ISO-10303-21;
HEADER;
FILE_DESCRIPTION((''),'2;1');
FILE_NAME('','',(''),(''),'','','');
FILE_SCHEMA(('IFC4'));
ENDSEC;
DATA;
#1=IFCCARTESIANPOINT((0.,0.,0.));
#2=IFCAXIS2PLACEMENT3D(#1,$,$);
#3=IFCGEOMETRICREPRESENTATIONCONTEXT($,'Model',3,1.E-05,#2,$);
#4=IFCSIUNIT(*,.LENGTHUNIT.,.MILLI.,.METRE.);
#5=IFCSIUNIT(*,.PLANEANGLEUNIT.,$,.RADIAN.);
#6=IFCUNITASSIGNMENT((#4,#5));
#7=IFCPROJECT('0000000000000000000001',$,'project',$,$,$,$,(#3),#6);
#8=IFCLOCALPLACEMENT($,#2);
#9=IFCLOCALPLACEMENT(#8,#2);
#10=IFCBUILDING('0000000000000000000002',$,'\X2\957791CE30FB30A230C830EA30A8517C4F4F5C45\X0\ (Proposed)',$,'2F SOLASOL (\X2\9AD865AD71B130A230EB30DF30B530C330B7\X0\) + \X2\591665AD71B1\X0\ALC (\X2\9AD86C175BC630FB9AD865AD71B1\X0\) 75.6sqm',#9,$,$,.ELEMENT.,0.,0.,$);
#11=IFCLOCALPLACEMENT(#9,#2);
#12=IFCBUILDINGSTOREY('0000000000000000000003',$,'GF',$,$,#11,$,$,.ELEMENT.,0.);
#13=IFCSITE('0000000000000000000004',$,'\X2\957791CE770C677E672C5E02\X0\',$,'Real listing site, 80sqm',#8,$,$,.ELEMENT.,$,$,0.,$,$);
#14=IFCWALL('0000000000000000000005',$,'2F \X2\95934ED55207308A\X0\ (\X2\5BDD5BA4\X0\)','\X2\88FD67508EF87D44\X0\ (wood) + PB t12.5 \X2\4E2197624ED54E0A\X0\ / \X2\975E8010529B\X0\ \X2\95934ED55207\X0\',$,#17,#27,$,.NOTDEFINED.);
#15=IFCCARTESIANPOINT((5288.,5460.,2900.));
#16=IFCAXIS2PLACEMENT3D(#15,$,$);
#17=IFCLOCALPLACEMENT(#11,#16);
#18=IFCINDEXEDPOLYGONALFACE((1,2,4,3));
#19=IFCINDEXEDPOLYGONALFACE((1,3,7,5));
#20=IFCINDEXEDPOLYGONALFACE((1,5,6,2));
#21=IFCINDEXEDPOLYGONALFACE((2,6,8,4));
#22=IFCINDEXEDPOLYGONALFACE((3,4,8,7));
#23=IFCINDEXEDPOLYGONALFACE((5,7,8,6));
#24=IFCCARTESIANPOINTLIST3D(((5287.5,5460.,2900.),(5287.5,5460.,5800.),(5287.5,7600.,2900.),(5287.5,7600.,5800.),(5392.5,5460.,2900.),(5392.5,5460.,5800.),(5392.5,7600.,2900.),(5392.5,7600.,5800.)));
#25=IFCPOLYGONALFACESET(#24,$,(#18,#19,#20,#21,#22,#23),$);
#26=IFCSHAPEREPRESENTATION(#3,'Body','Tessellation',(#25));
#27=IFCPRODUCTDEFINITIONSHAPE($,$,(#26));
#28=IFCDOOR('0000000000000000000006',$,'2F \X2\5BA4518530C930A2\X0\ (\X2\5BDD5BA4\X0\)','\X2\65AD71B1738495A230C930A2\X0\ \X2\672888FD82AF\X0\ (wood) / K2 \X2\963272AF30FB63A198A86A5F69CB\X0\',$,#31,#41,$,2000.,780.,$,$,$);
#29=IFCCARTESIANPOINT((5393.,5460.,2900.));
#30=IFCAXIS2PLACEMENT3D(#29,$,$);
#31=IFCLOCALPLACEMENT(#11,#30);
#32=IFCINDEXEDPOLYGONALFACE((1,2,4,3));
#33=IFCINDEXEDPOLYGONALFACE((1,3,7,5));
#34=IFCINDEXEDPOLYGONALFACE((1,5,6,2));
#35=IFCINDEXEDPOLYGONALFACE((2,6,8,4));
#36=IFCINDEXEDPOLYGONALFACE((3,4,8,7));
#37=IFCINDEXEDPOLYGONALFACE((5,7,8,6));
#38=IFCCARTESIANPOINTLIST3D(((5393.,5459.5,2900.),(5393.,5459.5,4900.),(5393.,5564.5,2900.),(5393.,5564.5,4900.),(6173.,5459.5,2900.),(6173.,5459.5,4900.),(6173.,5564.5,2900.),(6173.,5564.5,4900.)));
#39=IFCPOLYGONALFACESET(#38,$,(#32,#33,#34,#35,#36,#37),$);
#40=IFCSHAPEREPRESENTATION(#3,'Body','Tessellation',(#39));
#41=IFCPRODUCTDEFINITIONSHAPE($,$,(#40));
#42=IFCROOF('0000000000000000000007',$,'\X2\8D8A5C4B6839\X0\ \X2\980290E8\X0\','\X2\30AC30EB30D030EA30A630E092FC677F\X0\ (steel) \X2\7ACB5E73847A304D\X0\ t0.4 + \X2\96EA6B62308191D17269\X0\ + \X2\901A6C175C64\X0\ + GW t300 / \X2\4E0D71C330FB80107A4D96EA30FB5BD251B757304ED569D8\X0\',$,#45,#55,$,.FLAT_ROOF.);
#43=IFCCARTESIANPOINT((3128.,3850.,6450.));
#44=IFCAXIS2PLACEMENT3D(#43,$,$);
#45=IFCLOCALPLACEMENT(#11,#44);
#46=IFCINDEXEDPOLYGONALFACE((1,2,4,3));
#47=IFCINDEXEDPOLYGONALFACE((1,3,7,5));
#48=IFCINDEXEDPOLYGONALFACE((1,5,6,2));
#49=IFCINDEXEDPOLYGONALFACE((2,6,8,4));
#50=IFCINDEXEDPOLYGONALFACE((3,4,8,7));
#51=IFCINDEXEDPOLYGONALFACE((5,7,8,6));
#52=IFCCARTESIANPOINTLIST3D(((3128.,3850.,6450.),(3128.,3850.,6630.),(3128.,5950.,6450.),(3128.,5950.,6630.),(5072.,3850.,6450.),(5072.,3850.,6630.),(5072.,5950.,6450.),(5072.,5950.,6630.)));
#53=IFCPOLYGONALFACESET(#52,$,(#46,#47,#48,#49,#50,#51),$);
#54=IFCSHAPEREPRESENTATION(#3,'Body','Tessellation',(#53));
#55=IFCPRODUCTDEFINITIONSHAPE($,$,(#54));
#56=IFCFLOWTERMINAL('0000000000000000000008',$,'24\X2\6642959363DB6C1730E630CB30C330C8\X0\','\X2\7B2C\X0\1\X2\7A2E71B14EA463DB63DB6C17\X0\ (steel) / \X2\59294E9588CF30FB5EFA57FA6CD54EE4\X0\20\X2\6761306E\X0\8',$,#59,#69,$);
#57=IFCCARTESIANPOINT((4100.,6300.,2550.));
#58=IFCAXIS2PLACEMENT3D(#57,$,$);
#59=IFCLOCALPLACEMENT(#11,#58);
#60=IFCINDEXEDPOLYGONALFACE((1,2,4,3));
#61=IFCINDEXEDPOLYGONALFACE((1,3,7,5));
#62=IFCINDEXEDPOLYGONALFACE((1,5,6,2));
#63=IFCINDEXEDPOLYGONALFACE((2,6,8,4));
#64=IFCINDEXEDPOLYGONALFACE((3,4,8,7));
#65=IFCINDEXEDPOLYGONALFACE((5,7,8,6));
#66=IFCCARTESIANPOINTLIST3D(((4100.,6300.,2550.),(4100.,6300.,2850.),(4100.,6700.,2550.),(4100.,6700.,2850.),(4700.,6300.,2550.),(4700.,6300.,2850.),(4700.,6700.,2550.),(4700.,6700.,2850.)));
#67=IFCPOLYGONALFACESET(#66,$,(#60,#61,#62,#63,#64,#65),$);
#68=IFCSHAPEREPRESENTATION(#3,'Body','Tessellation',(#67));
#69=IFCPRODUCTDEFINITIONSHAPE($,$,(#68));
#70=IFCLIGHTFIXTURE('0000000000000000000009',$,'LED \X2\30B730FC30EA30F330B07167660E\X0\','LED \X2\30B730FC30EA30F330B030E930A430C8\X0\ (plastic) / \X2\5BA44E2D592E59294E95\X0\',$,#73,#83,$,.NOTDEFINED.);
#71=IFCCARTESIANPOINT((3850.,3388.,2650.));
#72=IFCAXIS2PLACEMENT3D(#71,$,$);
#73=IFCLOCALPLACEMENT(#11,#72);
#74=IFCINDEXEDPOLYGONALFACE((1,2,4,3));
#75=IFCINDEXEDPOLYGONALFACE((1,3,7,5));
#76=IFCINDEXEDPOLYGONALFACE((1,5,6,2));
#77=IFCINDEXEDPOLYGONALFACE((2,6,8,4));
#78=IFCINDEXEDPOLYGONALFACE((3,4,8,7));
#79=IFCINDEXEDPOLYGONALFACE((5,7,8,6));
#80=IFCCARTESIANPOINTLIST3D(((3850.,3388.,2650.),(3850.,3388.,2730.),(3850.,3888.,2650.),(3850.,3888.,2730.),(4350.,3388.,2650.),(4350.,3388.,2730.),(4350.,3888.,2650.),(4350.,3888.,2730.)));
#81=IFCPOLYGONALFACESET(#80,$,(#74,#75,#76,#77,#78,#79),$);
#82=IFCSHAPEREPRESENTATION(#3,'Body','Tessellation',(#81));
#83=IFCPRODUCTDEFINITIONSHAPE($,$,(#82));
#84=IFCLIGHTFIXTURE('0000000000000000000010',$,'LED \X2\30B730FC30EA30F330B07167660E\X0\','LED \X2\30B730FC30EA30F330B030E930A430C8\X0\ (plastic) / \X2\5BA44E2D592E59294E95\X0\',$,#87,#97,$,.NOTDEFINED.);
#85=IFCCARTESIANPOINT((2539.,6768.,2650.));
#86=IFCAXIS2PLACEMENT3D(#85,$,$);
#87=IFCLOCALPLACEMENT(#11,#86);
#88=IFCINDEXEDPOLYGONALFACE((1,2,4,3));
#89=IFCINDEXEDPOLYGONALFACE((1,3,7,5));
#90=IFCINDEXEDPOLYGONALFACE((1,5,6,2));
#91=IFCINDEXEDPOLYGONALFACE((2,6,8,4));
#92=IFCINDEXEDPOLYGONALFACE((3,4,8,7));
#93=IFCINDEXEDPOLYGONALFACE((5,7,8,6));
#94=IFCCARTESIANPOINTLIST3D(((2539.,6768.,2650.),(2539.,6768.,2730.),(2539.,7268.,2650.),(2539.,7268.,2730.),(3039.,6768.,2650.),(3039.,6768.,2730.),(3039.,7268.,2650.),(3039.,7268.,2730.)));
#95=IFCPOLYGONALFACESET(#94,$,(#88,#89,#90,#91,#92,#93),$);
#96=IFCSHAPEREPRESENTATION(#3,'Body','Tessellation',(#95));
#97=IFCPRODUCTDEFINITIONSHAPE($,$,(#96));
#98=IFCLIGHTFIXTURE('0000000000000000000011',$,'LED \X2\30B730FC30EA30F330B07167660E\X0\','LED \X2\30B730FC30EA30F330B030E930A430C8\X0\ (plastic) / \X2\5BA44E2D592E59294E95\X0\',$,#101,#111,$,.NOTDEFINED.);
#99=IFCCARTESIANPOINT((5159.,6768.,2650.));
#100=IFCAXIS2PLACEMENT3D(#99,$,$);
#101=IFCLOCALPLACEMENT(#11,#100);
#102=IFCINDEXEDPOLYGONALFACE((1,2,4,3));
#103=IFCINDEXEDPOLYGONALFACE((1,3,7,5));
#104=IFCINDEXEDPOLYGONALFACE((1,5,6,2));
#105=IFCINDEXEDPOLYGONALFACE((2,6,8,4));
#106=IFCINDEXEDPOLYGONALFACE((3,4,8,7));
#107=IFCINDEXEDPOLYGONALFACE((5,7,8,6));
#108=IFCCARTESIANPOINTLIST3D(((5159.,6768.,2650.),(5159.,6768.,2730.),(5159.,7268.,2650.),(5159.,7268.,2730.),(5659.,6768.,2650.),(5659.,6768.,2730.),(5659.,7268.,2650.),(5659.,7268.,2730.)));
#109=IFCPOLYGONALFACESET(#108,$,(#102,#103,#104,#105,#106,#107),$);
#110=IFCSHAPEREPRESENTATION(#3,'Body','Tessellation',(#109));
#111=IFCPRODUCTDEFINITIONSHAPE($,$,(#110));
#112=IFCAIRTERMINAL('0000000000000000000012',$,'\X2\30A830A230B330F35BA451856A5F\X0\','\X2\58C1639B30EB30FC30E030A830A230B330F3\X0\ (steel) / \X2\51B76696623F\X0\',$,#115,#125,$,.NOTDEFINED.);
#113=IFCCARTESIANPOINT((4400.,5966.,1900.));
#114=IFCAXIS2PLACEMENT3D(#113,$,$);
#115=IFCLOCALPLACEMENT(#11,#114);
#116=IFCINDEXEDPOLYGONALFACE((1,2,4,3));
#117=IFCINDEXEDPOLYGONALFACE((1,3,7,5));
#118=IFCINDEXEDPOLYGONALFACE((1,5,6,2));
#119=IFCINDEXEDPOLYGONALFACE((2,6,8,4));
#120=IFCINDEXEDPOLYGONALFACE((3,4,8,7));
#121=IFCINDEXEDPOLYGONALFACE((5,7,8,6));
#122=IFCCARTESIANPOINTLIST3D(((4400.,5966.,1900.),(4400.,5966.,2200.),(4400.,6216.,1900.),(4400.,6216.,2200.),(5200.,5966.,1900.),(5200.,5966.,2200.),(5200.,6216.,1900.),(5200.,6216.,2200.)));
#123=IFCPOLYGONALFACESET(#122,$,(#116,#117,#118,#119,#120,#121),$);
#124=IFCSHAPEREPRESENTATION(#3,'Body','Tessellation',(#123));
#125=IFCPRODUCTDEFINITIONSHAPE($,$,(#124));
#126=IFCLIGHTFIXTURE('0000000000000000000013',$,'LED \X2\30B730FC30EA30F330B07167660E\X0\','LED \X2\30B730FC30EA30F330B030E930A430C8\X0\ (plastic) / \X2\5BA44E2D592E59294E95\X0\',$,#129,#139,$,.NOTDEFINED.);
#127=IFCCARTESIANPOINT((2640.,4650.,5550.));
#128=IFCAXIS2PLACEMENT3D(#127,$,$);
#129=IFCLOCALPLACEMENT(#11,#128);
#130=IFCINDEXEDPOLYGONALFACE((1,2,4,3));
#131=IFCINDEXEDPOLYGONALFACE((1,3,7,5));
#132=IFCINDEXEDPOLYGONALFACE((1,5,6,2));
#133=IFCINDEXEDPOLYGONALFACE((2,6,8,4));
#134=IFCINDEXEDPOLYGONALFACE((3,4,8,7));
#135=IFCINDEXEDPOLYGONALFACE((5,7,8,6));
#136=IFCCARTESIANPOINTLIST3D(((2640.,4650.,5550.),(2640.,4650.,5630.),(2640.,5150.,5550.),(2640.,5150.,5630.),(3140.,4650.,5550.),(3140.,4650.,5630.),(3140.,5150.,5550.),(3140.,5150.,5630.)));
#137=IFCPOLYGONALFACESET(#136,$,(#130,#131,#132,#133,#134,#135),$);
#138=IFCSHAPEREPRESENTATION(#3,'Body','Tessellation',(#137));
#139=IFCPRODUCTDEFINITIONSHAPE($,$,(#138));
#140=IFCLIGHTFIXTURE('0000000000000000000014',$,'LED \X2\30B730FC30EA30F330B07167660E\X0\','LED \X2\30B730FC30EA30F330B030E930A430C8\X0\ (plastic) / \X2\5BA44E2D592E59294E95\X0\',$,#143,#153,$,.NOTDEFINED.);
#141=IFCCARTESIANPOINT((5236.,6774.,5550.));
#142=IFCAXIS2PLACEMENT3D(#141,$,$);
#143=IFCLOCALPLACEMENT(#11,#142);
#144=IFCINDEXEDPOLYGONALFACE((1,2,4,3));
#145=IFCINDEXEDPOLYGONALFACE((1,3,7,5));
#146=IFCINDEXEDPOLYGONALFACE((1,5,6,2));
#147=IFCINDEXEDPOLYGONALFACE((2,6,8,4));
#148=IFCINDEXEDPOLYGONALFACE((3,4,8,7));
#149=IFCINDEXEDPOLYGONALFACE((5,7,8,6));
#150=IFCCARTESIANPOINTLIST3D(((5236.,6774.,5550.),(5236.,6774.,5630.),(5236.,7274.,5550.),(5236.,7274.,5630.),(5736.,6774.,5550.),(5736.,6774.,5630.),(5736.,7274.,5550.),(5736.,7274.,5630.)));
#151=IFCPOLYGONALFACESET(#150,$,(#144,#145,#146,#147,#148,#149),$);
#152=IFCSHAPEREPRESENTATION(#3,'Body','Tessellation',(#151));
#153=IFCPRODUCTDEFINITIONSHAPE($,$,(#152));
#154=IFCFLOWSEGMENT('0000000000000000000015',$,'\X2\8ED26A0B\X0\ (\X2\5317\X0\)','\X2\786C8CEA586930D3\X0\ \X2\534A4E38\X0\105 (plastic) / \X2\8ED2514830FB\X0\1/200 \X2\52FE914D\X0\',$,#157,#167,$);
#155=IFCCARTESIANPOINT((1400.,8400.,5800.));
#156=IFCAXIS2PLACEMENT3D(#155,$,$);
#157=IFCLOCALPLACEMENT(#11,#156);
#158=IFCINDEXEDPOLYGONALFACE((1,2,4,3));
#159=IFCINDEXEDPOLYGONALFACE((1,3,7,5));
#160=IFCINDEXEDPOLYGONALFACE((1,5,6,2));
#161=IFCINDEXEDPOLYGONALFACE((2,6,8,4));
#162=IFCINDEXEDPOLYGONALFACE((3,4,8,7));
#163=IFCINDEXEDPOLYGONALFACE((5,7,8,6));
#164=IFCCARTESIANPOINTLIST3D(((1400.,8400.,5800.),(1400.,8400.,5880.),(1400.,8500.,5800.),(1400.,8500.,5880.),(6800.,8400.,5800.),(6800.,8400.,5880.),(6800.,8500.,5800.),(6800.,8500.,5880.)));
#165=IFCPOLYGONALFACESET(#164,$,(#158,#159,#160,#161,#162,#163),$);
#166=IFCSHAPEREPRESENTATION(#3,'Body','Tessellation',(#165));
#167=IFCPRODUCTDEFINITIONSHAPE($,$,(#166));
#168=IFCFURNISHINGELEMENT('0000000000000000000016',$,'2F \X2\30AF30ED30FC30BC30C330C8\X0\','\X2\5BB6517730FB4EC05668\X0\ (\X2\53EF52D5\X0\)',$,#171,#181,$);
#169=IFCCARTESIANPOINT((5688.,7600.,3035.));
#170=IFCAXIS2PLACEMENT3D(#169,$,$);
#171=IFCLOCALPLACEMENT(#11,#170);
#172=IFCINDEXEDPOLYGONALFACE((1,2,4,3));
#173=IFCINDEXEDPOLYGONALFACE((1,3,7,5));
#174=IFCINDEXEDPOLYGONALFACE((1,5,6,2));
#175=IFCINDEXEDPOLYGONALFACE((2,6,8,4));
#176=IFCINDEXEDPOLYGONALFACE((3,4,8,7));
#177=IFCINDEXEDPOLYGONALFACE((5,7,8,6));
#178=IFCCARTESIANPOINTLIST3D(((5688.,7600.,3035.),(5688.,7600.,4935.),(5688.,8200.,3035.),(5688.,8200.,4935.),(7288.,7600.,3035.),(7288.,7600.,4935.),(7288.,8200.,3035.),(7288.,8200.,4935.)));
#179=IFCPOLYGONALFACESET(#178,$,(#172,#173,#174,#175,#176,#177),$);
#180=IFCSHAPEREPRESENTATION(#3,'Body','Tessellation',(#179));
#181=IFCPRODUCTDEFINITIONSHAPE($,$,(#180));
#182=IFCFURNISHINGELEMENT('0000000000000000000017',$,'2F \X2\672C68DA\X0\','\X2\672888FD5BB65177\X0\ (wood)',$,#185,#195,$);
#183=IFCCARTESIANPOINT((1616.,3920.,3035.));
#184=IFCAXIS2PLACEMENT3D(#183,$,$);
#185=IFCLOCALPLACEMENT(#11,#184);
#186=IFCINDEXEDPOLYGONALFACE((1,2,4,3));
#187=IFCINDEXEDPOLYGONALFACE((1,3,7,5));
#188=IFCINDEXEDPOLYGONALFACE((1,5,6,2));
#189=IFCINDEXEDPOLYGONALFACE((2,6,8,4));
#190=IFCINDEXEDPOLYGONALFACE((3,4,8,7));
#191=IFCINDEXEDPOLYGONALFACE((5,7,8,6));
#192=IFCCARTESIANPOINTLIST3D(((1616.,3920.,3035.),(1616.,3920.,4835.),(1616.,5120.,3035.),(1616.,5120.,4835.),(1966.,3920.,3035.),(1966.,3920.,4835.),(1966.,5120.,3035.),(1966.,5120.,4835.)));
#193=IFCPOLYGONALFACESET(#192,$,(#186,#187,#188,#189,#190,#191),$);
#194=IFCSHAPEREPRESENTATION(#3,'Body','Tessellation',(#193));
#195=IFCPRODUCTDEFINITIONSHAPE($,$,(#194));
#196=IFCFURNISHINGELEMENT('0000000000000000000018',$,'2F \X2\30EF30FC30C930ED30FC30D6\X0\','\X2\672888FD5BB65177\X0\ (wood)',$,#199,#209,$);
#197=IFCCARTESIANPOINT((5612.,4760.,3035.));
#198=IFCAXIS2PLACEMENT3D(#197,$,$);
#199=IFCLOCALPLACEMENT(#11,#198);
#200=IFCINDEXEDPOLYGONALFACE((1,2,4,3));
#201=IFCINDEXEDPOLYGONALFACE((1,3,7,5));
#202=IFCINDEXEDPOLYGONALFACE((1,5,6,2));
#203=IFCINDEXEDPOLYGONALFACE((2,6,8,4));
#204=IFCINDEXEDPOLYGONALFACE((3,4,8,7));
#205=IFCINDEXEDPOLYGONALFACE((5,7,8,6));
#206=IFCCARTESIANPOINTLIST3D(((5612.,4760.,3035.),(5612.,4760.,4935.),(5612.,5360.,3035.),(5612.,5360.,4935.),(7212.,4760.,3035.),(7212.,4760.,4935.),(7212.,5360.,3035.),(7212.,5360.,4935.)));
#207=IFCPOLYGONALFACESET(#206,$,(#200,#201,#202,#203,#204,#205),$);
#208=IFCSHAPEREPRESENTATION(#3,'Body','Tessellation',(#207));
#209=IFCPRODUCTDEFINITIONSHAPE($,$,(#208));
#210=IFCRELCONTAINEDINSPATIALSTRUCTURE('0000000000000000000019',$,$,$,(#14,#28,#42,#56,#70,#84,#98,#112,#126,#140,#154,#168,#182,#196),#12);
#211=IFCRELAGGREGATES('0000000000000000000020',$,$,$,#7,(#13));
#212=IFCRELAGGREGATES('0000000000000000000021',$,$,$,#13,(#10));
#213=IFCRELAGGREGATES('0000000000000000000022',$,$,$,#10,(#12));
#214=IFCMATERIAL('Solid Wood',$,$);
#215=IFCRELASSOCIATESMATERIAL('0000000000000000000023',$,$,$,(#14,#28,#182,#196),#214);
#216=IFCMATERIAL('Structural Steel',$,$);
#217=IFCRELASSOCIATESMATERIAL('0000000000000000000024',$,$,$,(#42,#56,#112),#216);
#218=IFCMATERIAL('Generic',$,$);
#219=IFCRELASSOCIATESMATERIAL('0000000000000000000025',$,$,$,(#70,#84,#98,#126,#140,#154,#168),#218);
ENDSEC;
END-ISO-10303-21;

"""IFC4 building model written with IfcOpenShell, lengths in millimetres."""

from ifc_helpers import new_model, si_unit, frame, frame_2d, origin, place, context, project, spatial, rectangle, extrude, material, element, save


model = new_model("IFC4")

# Units and contexts
model_context = context("Model", 3, precision=1e-05, world=origin())
ifc_project = project(units=[si_unit("LENGTHUNIT", "METRE", prefix="MILLI"), si_unit("PLANEANGLEUNIT", "RADIAN")], contexts=[model_context])

# Site, building, storey
site_placement = place(None, origin())
site = spatial("IfcSite", under=ifc_project, at=site_placement, Name="長野県松本市", ObjectType="Real listing site, 80sqm", CompositionType="ELEMENT", RefElevation=0.0)
building_placement = place(site_placement, origin())
building = spatial("IfcBuilding", under=site, at=building_placement, Name="長野・アトリエ兼住居 (Proposed)", ObjectType="2F SOLASOL (高断熱アルミサッシ) + 外断熱ALC (高気密・高断熱) 75.6sqm", CompositionType="ELEMENT", ElevationOfRefHeight=0.0, ElevationOfTerrain=0.0)
storey_placement = place(building_placement, origin())
storey = spatial("IfcBuildingStorey", under=building, at=storey_placement, Name="GF", CompositionType="ELEMENT", Elevation=0.0)

# Shared definitions
ifc_material_1 = material(Name="Solid Wood")

# Wall
wall_1_placement = place(storey_placement, frame((5288.0, 5460.0, 2900.0)))
element("IfcWall", 1, at=wall_1_placement, inside=storey, material=ifc_material_1, Name="2F 間仕切り (寝室)", Description="製材軸組 (wood) + PB t12.5 両面仕上 / 非耐力 間仕切", PredefinedType="NOTDEFINED", context=model_context, shape_type="SweptSolid", body=[
    extrude(rectangle(XDim=105.0, YDim=2140.0, at=frame_2d((52.0, 1070.0))), frame((5288.0, 5460.0, 2900.0)), (0.0, 0.0, 1.0), 2900.0),
])

# Door
door_placement = place(storey_placement, frame((5393.0, 5460.0, 2900.0)))
element("IfcDoor", 2, at=door_placement, inside=storey, material=ifc_material_1, Name="2F 室内ドア (寝室)", Description="断熱玄関ドア 木製芯 (wood) / K2 防犯・採風機構", OverallHeight=2000.0, OverallWidth=780.0, context=model_context, shape_type="SweptSolid", body=[
    extrude(rectangle(XDim=780.0, YDim=105.0, at=frame_2d((390.0, 52.0))), frame((5393.0, 5460.0, 2900.0)), (0.0, 0.0, 1.0), 2000.0),
])

# Roof
ifc_material_2 = material(Name="Structural Steel")
roof_placement = place(storey_placement, frame((3128.0, 3850.0, 6450.0)))
element("IfcRoof", 3, at=roof_placement, inside=storey, material=ifc_material_2, Name="越屋根 頂部", Description="ガルバリウム鋼板 (steel) 立平葺き t0.4 + 雪止め金物 + 通気層 + GW t300 / 不燃・耐積雪・寒冷地仕様", PredefinedType="FLAT_ROOF", context=model_context, shape_type="SweptSolid", body=[
    extrude(rectangle(XDim=1944.0, YDim=2100.0, at=frame_2d((972.0, 1050.0))), frame((3128.0, 3850.0, 6450.0)), (0.0, 0.0, 1.0), 180.0),
])

# Flow terminal
flow_terminal_placement = place(storey_placement, frame((4100.0, 6300.0, 2550.0)))
element("IfcFlowTerminal", 4, at=flow_terminal_placement, inside=storey, material=ifc_material_2, Name="24時間換気ユニット", Description="第1種熱交換換気 (steel) / 天井裏・建基法令20条の8", context=model_context, shape_type="SweptSolid", body=[
    extrude(rectangle(XDim=600.0, YDim=400.0, at=frame_2d((300.0, 200.0))), frame((4100.0, 6300.0, 2550.0)), (0.0, 0.0, 1.0), 300.0),
])

# Light fixtures
ifc_material_3 = material(Name="Generic")
light_fixture_1_placement = place(storey_placement, frame((3850.0, 3388.0, 2650.0)))
element("IfcLightFixture", 5, at=light_fixture_1_placement, inside=storey, material=ifc_material_3, Name="LED シーリング照明", Description="LED シーリングライト (plastic) / 室中央天井", PredefinedType="NOTDEFINED", context=model_context, shape_type="SweptSolid", body=[
    extrude(rectangle(XDim=500.0, YDim=500.0, at=frame_2d((250.0, 250.0))), frame((3850.0, 3388.0, 2650.0)), (0.0, 0.0, 1.0), 80.0),
])
light_fixture_2_placement = place(storey_placement, frame((2539.0, 6768.0, 2650.0)))
element("IfcLightFixture", 6, at=light_fixture_2_placement, inside=storey, material=ifc_material_3, Name="LED シーリング照明", Description="LED シーリングライト (plastic) / 室中央天井", PredefinedType="NOTDEFINED", context=model_context, shape_type="SweptSolid", body=[
    extrude(rectangle(XDim=500.0, YDim=500.0, at=frame_2d((250.0, 250.0))), frame((2539.0, 6768.0, 2650.0)), (0.0, 0.0, 1.0), 80.0),
])
light_fixture_3_placement = place(storey_placement, frame((5159.0, 6768.0, 2650.0)))
element("IfcLightFixture", 7, at=light_fixture_3_placement, inside=storey, material=ifc_material_3, Name="LED シーリング照明", Description="LED シーリングライト (plastic) / 室中央天井", PredefinedType="NOTDEFINED", context=model_context, shape_type="SweptSolid", body=[
    extrude(rectangle(XDim=500.0, YDim=500.0, at=frame_2d((250.0, 250.0))), frame((5159.0, 6768.0, 2650.0)), (0.0, 0.0, 1.0), 80.0),
])

# Air terminal
air_terminal_placement = place(storey_placement, frame((4400.0, 5966.0, 1900.0)))
element("IfcAirTerminal", 8, at=air_terminal_placement, inside=storey, material=ifc_material_2, Name="エアコン室内機", Description="壁掛ルームエアコン (steel) / 冷暖房", PredefinedType="NOTDEFINED", context=model_context, shape_type="SweptSolid", body=[
    extrude(rectangle(XDim=800.0, YDim=250.0, at=frame_2d((400.0, 125.0))), frame((4400.0, 5966.0, 1900.0)), (0.0, 0.0, 1.0), 300.0),
])

# Light fixtures
light_fixture_4_placement = place(storey_placement, frame((2640.0, 4650.0, 5550.0)))
element("IfcLightFixture", 9, at=light_fixture_4_placement, inside=storey, material=ifc_material_3, Name="LED シーリング照明", Description="LED シーリングライト (plastic) / 室中央天井", PredefinedType="NOTDEFINED", context=model_context, shape_type="SweptSolid", body=[
    extrude(rectangle(XDim=500.0, YDim=500.0, at=frame_2d((250.0, 250.0))), frame((2640.0, 4650.0, 5550.0)), (0.0, 0.0, 1.0), 80.0),
])
light_fixture_5_placement = place(storey_placement, frame((5236.0, 6774.0, 5550.0)))
element("IfcLightFixture", 10, at=light_fixture_5_placement, inside=storey, material=ifc_material_3, Name="LED シーリング照明", Description="LED シーリングライト (plastic) / 室中央天井", PredefinedType="NOTDEFINED", context=model_context, shape_type="SweptSolid", body=[
    extrude(rectangle(XDim=500.0, YDim=500.0, at=frame_2d((250.0, 250.0))), frame((5236.0, 6774.0, 5550.0)), (0.0, 0.0, 1.0), 80.0),
])

# Flow segment
flow_segment_placement = place(storey_placement, frame((1400.0, 8400.0, 5800.0)))
element("IfcFlowSegment", 11, at=flow_segment_placement, inside=storey, material=ifc_material_3, Name="軒樋 (北)", Description="硬質塩ビ 半丸105 (plastic) / 軒先・1/200 勾配", context=model_context, shape_type="SweptSolid", body=[
    extrude(rectangle(XDim=5400.0, YDim=100.0, at=frame_2d((2700.0, 50.0))), frame((1400.0, 8400.0, 5800.0)), (0.0, 0.0, 1.0), 80.0),
])

# Furnishing elements
furnishing_1_placement = place(storey_placement, frame((5688.0, 7600.0, 3035.0)))
element("IfcFurnishingElement", 12, at=furnishing_1_placement, inside=storey, material=ifc_material_3, Name="2F クローゼット", Description="家具・什器 (可動)", context=model_context, shape_type="SweptSolid", body=[
    extrude(rectangle(XDim=1600.0, YDim=600.0, at=frame_2d((800.0, 300.0))), frame((5688.0, 7600.0, 3035.0)), (0.0, 0.0, 1.0), 1900.0),
])
furnishing_2_placement = place(storey_placement, frame((1616.0, 3920.0, 3035.0)))
element("IfcFurnishingElement", 13, at=furnishing_2_placement, inside=storey, material=ifc_material_1, Name="2F 本棚", Description="木製家具 (wood)", context=model_context, shape_type="SweptSolid", body=[
    extrude(rectangle(XDim=350.0, YDim=1200.0, at=frame_2d((175.0, 600.0))), frame((1616.0, 3920.0, 3035.0)), (0.0, 0.0, 1.0), 1800.0),
])
furnishing_3_placement = place(storey_placement, frame((5612.0, 4760.0, 3035.0)))
element("IfcFurnishingElement", 14, at=furnishing_3_placement, inside=storey, material=ifc_material_1, Name="2F ワードローブ", Description="木製家具 (wood)", context=model_context, shape_type="SweptSolid", body=[
    extrude(rectangle(XDim=1600.0, YDim=600.0, at=frame_2d((800.0, 300.0))), frame((5612.0, 4760.0, 3035.0)), (0.0, 0.0, 1.0), 1900.0),
])

save(model, "model.ifc")
